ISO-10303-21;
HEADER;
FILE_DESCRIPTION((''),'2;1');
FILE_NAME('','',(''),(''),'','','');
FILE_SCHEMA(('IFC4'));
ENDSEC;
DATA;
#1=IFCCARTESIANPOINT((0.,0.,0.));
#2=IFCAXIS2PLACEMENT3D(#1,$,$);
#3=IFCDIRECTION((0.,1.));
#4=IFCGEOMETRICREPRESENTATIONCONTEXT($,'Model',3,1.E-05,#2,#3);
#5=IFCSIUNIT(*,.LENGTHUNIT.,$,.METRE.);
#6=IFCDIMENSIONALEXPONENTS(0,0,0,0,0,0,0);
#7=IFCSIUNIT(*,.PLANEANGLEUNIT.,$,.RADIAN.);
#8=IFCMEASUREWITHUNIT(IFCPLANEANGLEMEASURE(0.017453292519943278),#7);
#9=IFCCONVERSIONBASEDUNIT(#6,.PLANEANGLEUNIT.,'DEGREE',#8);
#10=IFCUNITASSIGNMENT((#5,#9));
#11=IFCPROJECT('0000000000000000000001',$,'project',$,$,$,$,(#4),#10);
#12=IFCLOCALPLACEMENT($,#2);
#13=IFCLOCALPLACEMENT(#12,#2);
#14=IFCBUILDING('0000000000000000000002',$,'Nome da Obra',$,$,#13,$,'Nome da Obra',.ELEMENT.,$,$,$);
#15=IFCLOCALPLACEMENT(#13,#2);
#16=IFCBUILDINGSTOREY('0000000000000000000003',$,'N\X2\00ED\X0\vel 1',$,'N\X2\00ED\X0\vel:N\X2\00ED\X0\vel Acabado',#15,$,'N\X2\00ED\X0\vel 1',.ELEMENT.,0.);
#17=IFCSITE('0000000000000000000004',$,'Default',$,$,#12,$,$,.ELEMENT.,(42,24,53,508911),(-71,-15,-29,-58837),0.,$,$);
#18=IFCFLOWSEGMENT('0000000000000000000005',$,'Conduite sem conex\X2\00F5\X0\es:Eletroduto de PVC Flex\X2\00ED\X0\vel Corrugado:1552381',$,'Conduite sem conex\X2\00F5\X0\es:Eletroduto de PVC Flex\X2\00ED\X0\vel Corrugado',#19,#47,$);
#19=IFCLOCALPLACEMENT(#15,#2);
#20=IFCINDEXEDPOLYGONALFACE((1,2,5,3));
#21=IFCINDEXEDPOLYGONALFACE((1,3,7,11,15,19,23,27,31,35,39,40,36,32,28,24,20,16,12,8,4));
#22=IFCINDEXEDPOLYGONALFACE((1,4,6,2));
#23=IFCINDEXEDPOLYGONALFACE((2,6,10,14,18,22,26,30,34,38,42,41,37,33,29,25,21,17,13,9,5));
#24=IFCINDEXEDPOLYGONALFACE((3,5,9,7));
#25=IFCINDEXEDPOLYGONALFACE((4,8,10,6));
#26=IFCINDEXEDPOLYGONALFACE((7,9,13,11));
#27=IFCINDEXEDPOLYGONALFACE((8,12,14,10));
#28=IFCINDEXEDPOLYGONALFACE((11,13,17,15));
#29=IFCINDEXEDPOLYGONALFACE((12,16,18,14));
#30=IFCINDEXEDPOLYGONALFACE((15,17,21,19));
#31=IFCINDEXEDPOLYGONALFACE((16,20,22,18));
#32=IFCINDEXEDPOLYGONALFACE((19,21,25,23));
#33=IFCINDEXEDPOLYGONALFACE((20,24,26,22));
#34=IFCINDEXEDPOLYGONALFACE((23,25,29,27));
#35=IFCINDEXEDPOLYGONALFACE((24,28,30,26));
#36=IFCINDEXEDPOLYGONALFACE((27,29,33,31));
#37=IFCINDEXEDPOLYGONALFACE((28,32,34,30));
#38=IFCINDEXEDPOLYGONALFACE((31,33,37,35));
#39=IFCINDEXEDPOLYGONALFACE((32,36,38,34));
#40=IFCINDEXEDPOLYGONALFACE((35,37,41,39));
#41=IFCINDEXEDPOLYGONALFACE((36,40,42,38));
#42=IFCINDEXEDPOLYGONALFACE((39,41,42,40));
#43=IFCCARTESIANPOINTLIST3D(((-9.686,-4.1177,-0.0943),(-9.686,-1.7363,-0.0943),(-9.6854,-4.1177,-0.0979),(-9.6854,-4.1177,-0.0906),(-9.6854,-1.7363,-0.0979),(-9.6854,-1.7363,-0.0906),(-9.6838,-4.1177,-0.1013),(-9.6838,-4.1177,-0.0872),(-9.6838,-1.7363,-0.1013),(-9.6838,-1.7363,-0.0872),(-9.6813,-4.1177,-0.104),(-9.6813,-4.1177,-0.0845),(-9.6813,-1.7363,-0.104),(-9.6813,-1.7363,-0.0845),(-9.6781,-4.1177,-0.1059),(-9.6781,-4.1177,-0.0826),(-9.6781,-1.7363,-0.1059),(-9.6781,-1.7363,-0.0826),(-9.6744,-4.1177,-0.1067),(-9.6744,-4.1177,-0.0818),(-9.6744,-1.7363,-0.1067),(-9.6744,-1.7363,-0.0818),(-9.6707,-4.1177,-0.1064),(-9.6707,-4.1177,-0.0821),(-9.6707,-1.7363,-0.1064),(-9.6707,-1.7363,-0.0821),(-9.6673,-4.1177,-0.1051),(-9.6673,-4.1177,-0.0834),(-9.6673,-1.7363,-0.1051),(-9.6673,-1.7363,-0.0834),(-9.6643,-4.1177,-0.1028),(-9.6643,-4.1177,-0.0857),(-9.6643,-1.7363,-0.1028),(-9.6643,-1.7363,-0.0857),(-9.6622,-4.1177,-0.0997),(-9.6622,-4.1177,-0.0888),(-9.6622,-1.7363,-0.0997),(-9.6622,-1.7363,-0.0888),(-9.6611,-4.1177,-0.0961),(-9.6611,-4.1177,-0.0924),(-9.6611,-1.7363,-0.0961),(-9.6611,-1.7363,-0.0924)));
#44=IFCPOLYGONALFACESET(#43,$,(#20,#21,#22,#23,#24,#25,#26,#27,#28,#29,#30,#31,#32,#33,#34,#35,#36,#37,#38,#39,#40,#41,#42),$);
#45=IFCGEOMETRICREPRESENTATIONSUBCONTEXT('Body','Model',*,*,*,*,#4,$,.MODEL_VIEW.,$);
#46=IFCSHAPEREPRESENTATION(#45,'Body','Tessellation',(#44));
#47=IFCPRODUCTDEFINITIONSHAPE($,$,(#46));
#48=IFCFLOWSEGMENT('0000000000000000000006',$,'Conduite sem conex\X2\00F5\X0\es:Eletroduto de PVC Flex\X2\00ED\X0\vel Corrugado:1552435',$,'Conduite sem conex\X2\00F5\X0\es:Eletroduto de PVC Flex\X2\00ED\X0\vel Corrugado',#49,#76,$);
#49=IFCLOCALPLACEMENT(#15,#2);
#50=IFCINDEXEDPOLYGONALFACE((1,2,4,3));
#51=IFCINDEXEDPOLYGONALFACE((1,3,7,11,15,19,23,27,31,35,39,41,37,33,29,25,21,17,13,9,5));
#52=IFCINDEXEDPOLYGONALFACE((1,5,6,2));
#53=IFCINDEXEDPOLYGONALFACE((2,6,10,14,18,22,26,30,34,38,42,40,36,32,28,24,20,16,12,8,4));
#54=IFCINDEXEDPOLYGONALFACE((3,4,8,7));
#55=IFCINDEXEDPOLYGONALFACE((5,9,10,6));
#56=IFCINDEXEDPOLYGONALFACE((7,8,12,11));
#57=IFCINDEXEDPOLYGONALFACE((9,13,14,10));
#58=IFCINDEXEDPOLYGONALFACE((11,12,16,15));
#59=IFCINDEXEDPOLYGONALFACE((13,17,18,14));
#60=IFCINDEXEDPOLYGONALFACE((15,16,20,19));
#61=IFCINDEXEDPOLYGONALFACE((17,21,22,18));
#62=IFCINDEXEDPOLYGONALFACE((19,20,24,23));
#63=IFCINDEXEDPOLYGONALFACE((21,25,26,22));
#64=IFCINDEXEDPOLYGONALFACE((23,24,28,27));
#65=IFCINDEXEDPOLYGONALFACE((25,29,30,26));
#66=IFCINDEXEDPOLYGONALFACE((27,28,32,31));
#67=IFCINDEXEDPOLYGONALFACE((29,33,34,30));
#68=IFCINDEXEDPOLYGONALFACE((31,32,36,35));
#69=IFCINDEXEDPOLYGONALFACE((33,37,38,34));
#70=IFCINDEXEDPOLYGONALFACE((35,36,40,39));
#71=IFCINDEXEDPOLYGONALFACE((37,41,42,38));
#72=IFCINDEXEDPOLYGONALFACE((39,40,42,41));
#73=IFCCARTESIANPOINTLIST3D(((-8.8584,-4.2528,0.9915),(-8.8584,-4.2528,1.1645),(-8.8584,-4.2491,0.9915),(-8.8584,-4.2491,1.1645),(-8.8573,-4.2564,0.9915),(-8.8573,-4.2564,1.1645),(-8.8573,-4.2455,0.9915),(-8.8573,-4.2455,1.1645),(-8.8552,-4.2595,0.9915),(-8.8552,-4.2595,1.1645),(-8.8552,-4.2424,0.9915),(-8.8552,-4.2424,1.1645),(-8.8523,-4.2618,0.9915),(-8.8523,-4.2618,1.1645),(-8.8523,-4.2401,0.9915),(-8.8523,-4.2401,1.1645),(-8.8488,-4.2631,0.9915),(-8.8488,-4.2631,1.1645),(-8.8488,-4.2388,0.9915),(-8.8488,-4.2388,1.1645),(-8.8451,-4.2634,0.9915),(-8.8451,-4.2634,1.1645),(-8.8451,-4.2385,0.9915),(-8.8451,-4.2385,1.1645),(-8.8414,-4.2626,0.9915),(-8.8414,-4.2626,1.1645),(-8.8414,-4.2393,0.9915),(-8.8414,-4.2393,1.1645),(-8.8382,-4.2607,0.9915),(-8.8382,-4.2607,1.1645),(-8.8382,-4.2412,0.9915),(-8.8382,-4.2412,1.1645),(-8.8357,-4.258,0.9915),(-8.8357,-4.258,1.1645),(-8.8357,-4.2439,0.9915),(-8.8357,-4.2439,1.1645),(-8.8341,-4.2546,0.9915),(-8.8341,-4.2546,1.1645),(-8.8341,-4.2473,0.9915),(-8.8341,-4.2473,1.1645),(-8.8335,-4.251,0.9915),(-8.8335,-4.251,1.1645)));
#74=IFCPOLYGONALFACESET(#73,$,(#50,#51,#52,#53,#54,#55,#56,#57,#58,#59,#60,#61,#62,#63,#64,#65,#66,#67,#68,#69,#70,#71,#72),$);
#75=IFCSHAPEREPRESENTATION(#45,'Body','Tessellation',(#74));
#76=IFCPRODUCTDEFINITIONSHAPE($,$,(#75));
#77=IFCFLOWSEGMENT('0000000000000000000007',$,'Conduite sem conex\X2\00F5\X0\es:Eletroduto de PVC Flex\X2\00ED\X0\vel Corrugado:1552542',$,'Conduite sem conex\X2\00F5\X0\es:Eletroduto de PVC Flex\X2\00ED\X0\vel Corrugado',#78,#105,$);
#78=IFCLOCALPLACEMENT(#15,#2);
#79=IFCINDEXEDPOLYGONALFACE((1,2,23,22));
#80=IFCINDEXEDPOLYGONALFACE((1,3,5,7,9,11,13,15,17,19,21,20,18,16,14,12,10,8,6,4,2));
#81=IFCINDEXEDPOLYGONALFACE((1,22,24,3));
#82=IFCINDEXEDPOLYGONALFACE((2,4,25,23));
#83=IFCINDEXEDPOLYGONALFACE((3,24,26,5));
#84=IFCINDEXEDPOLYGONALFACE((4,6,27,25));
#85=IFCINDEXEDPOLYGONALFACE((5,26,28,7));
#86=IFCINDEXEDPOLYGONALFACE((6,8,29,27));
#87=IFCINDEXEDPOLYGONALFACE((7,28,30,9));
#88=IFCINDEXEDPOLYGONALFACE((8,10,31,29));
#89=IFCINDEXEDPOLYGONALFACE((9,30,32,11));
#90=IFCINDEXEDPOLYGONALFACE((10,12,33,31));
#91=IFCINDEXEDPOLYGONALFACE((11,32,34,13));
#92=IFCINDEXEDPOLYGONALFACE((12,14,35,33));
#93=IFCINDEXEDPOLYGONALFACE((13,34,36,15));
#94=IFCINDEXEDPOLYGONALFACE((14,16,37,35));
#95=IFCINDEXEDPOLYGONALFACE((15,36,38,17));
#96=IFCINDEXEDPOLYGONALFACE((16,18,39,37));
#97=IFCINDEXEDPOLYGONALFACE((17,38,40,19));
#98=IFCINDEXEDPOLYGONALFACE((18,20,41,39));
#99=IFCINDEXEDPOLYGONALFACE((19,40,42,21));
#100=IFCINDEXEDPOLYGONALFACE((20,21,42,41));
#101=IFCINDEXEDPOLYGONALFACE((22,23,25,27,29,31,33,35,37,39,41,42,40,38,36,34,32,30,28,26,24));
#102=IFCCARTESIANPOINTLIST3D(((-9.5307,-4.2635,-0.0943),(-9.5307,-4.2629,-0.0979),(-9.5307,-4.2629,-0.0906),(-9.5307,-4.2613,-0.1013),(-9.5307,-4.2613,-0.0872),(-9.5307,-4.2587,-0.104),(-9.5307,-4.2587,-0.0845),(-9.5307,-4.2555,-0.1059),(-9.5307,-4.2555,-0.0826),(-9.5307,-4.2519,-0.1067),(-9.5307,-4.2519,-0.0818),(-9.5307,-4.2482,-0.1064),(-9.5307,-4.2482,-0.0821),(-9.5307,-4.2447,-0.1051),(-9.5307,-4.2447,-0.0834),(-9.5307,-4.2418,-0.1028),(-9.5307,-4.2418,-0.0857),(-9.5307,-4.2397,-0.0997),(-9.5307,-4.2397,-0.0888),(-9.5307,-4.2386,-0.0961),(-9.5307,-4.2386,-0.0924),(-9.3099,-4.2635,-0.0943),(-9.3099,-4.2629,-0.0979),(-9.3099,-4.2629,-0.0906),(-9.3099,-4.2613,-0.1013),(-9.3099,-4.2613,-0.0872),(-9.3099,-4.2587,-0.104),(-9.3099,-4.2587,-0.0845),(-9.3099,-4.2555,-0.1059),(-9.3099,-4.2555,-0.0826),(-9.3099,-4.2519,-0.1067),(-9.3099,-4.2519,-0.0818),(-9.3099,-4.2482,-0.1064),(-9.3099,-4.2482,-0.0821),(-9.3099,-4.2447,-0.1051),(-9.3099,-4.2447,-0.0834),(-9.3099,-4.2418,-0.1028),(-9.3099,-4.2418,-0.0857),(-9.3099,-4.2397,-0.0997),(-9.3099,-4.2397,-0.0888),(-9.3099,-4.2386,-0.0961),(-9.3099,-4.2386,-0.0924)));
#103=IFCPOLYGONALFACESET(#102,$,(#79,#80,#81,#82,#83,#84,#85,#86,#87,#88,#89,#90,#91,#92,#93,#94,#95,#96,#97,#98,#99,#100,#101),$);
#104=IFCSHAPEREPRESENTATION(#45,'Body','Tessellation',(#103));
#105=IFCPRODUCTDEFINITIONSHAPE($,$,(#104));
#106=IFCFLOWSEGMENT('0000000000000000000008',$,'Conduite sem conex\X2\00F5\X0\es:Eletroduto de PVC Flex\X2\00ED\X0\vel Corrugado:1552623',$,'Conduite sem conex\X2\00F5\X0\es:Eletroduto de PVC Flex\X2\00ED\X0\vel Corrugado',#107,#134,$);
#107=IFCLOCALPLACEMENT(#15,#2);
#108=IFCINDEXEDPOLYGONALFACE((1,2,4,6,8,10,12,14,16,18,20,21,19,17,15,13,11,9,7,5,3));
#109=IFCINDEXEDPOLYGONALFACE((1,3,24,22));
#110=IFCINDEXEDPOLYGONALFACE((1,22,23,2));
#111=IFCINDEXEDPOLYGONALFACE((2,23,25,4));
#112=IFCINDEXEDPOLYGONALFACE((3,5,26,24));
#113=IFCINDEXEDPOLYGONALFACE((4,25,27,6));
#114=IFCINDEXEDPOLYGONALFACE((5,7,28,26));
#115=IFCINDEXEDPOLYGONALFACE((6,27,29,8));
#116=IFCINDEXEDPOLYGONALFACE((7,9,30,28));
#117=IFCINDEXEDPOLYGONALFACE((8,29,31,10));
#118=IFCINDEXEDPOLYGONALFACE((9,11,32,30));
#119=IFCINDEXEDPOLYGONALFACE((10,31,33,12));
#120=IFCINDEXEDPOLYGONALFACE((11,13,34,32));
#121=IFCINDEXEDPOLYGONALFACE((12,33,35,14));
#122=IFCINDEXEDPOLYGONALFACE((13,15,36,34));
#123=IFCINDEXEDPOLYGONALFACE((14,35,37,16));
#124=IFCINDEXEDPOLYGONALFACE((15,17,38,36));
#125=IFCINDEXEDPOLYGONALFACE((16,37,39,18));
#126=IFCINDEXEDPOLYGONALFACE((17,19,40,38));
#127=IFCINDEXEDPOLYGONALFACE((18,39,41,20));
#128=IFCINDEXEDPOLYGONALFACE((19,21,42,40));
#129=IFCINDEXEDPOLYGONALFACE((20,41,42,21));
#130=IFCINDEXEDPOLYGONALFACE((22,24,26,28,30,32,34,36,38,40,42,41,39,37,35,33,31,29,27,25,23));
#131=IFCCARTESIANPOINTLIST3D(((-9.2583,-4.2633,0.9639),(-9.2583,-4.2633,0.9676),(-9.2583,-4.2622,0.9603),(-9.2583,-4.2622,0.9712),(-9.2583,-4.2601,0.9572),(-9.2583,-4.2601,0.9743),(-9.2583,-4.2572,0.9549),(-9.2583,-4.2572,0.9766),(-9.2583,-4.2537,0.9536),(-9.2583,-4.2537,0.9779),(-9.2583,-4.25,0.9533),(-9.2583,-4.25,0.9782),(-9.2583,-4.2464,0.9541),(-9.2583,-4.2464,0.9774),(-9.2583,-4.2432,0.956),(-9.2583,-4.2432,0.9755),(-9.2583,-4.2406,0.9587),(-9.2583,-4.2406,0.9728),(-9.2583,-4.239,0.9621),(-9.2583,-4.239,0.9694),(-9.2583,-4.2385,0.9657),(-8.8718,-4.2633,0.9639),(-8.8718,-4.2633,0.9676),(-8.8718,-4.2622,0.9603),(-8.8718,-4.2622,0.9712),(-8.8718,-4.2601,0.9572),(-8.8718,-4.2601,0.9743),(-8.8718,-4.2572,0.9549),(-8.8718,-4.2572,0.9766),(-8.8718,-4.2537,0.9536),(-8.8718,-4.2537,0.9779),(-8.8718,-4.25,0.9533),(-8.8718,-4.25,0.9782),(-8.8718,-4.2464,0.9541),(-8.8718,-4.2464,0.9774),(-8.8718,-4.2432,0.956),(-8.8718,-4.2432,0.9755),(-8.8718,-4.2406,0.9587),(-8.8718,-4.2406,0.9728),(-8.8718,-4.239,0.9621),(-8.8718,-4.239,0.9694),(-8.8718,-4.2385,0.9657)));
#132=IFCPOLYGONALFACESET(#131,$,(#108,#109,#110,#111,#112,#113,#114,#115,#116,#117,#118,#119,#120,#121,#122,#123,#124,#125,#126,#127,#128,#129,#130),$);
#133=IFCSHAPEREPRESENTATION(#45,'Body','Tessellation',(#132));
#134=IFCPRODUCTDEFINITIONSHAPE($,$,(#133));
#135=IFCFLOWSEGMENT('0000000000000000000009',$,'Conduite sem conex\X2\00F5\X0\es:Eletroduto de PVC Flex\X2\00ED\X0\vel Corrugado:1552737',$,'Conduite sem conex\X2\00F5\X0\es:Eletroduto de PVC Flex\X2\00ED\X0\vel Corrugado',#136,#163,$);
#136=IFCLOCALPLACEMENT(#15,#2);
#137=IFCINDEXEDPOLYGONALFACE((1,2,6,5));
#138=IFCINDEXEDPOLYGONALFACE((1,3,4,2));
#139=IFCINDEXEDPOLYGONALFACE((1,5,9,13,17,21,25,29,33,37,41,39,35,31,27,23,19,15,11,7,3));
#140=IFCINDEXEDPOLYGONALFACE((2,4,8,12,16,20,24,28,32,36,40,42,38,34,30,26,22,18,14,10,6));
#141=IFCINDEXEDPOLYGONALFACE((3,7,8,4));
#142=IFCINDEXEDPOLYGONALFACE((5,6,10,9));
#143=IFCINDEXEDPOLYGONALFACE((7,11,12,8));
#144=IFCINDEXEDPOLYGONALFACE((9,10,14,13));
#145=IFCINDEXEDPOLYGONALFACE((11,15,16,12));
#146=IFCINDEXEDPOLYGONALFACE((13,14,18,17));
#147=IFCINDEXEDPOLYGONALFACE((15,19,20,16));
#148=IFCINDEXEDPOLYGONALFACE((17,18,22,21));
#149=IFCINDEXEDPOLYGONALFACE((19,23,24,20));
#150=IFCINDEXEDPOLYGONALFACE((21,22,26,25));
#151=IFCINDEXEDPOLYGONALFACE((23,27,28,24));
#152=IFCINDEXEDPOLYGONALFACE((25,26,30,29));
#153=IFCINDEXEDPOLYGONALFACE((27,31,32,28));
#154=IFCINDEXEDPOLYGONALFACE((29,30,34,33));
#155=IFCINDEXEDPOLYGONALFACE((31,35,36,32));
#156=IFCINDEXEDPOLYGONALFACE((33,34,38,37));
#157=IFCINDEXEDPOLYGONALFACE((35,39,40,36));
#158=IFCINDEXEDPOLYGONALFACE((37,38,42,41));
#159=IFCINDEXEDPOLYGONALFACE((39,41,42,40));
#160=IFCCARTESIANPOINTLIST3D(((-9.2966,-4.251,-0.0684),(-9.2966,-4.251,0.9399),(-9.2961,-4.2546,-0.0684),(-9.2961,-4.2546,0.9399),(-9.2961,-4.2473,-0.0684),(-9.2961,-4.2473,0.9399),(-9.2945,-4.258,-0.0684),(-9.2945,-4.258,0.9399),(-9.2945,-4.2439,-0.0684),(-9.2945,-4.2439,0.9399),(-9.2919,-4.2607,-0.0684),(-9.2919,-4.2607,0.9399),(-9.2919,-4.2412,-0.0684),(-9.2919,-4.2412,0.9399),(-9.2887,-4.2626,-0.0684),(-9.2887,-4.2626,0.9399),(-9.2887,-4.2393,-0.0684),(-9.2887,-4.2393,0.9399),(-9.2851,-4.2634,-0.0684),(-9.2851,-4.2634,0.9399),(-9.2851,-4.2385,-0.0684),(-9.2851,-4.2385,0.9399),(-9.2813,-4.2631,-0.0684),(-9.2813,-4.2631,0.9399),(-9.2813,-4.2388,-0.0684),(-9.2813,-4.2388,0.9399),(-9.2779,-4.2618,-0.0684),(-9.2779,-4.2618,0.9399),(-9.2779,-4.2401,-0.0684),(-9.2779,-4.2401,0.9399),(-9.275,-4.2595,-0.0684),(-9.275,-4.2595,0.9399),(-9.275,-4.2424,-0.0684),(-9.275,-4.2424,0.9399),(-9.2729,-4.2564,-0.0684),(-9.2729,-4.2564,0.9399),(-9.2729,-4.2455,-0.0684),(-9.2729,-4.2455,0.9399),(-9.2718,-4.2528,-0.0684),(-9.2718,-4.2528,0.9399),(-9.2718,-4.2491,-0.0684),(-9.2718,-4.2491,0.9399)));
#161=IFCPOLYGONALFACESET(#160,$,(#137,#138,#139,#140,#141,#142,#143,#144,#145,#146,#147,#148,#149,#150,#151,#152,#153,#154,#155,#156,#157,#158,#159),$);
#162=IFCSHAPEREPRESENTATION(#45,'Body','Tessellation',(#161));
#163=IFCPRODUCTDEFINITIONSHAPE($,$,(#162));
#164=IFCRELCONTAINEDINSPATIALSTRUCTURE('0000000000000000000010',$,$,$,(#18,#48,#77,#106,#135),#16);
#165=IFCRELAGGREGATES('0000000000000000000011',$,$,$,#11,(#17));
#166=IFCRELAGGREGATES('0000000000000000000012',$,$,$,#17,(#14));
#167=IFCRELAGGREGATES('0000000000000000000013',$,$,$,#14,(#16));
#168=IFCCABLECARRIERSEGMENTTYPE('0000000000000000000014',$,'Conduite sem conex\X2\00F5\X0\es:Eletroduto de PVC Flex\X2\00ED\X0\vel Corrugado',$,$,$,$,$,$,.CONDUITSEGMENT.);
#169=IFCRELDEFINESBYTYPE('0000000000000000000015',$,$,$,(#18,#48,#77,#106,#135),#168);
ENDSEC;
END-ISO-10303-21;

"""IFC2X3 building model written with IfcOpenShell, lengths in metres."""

from ifc_helpers import new_model, entity, si_unit, converted_unit, direction, frame, frame_2d, origin, place, context, subcontext, project, spatial, circle, extrude, type_object, element, save


model = new_model("IFC2X3")

# Units and contexts
model_context = context("Model", 3, precision=1e-05, world=origin(), true_north=direction((0.0, 1.0)))
body_context = subcontext(model_context, "Body", "Model", "MODEL_VIEW")
ifc_project = project(units=[si_unit("LENGTHUNIT", "METRE"), converted_unit("PLANEANGLEUNIT", "DEGREE", entity("IfcPlaneAngleMeasure", 0.017453292519943278), si_unit("PLANEANGLEUNIT", "RADIAN"), dimensions=[0, 0, 0, 0, 0, 0, 0])], contexts=[model_context])

# Site, building, storey
site_placement = place(None, origin())
site = spatial("IfcSite", under=ifc_project, at=site_placement, Name="Default", CompositionType="ELEMENT", RefLatitude=(42, 24, 53, 508911), RefLongitude=(-71, -15, -29, -58837), RefElevation=0.0)
building_placement = place(site_placement, origin())
building = spatial("IfcBuilding", under=site, at=building_placement, Name="Nome da Obra", LongName="Nome da Obra", CompositionType="ELEMENT")
storey_placement = place(building_placement, origin())
storey = spatial("IfcBuildingStorey", under=building, at=storey_placement, Name="Nível 1", ObjectType="Nível:Nível Acabado", LongName="Nível 1", CompositionType="ELEMENT", Elevation=0.0)

# Flow segments
cable_carrier_segment_type = type_object("IfcCableCarrierSegmentType", Name="Conduite sem conexões:Eletroduto de PVC Flexível Corrugado", PredefinedType="CONDUITSEGMENT")
flow_segment_1_placement = place(storey_placement, origin())
element("IfcFlowSegment", 1, at=flow_segment_1_placement, inside=storey, type_object=cable_carrier_segment_type, Name="Conduite sem conexões:Eletroduto de PVC Flexível Corrugado:1552381", ObjectType="Conduite sem conexões:Eletroduto de PVC Flexível Corrugado", context=body_context, shape_type="SweptSolid", body=[
    extrude(circle(Radius=0.0125, at=frame_2d((0.0, 0.0), x_axis=(1.0, 0.0))), frame((-9.6735, -4.1177, -0.0943), z_axis=(0.0, 1.0, 0.0), x_axis=(-1.0, 0.0, 0.0)), (0.0, 0.0, 1.0), 2.3814),
])
flow_segment_2_placement = place(storey_placement, origin())
element("IfcFlowSegment", 2, at=flow_segment_2_placement, inside=storey, type_object=cable_carrier_segment_type, Name="Conduite sem conexões:Eletroduto de PVC Flexível Corrugado:1552435", ObjectType="Conduite sem conexões:Eletroduto de PVC Flexível Corrugado", context=body_context, shape_type="SweptSolid", body=[
    extrude(circle(Radius=0.0125, at=frame_2d((0.0, 0.0), x_axis=(1.0, 0.0))), frame((-8.846, -4.251, 0.9915)), (0.0, 0.0, 1.0), 0.173),
])
flow_segment_3_placement = place(storey_placement, origin())
element("IfcFlowSegment", 3, at=flow_segment_3_placement, inside=storey, type_object=cable_carrier_segment_type, Name="Conduite sem conexões:Eletroduto de PVC Flexível Corrugado:1552542", ObjectType="Conduite sem conexões:Eletroduto de PVC Flexível Corrugado", context=body_context, shape_type="SweptSolid", body=[
    extrude(circle(Radius=0.0125, at=frame_2d((0.0, 0.0), x_axis=(1.0, 0.0))), frame((-9.5307, -4.251, -0.0943), z_axis=(1.0, 0.0, 0.0), x_axis=(0.0, -1.0, 0.0)), (0.0, 0.0, 1.0), 0.2208),
])
flow_segment_4_placement = place(storey_placement, origin())
element("IfcFlowSegment", 4, at=flow_segment_4_placement, inside=storey, type_object=cable_carrier_segment_type, Name="Conduite sem conexões:Eletroduto de PVC Flexível Corrugado:1552623", ObjectType="Conduite sem conexões:Eletroduto de PVC Flexível Corrugado", context=body_context, shape_type="SweptSolid", body=[
    extrude(circle(Radius=0.0125, at=frame_2d((0.0, 0.0), x_axis=(1.0, 0.0))), frame((-9.2583, -4.251, 0.9657), z_axis=(1.0, 0.0, 0.0), x_axis=(0.0, 1.0, 0.0)), (0.0, 0.0, 1.0), 0.3865),
])
flow_segment_5_placement = place(storey_placement, origin())
element("IfcFlowSegment", 5, at=flow_segment_5_placement, inside=storey, type_object=cable_carrier_segment_type, Name="Conduite sem conexões:Eletroduto de PVC Flexível Corrugado:1552737", ObjectType="Conduite sem conexões:Eletroduto de PVC Flexível Corrugado", context=body_context, shape_type="SweptSolid", body=[
    extrude(circle(Radius=0.0125, at=frame_2d((0.0, 0.0), x_axis=(1.0, 0.0))), frame((-9.2841, -4.251, -0.0684), z_axis=(0.0, 0.0, 1.0), x_axis=(-1.0, 0.0, 0.0)), (0.0, 0.0, 1.0), 1.0084),
])

save(model, "model.ifc")
